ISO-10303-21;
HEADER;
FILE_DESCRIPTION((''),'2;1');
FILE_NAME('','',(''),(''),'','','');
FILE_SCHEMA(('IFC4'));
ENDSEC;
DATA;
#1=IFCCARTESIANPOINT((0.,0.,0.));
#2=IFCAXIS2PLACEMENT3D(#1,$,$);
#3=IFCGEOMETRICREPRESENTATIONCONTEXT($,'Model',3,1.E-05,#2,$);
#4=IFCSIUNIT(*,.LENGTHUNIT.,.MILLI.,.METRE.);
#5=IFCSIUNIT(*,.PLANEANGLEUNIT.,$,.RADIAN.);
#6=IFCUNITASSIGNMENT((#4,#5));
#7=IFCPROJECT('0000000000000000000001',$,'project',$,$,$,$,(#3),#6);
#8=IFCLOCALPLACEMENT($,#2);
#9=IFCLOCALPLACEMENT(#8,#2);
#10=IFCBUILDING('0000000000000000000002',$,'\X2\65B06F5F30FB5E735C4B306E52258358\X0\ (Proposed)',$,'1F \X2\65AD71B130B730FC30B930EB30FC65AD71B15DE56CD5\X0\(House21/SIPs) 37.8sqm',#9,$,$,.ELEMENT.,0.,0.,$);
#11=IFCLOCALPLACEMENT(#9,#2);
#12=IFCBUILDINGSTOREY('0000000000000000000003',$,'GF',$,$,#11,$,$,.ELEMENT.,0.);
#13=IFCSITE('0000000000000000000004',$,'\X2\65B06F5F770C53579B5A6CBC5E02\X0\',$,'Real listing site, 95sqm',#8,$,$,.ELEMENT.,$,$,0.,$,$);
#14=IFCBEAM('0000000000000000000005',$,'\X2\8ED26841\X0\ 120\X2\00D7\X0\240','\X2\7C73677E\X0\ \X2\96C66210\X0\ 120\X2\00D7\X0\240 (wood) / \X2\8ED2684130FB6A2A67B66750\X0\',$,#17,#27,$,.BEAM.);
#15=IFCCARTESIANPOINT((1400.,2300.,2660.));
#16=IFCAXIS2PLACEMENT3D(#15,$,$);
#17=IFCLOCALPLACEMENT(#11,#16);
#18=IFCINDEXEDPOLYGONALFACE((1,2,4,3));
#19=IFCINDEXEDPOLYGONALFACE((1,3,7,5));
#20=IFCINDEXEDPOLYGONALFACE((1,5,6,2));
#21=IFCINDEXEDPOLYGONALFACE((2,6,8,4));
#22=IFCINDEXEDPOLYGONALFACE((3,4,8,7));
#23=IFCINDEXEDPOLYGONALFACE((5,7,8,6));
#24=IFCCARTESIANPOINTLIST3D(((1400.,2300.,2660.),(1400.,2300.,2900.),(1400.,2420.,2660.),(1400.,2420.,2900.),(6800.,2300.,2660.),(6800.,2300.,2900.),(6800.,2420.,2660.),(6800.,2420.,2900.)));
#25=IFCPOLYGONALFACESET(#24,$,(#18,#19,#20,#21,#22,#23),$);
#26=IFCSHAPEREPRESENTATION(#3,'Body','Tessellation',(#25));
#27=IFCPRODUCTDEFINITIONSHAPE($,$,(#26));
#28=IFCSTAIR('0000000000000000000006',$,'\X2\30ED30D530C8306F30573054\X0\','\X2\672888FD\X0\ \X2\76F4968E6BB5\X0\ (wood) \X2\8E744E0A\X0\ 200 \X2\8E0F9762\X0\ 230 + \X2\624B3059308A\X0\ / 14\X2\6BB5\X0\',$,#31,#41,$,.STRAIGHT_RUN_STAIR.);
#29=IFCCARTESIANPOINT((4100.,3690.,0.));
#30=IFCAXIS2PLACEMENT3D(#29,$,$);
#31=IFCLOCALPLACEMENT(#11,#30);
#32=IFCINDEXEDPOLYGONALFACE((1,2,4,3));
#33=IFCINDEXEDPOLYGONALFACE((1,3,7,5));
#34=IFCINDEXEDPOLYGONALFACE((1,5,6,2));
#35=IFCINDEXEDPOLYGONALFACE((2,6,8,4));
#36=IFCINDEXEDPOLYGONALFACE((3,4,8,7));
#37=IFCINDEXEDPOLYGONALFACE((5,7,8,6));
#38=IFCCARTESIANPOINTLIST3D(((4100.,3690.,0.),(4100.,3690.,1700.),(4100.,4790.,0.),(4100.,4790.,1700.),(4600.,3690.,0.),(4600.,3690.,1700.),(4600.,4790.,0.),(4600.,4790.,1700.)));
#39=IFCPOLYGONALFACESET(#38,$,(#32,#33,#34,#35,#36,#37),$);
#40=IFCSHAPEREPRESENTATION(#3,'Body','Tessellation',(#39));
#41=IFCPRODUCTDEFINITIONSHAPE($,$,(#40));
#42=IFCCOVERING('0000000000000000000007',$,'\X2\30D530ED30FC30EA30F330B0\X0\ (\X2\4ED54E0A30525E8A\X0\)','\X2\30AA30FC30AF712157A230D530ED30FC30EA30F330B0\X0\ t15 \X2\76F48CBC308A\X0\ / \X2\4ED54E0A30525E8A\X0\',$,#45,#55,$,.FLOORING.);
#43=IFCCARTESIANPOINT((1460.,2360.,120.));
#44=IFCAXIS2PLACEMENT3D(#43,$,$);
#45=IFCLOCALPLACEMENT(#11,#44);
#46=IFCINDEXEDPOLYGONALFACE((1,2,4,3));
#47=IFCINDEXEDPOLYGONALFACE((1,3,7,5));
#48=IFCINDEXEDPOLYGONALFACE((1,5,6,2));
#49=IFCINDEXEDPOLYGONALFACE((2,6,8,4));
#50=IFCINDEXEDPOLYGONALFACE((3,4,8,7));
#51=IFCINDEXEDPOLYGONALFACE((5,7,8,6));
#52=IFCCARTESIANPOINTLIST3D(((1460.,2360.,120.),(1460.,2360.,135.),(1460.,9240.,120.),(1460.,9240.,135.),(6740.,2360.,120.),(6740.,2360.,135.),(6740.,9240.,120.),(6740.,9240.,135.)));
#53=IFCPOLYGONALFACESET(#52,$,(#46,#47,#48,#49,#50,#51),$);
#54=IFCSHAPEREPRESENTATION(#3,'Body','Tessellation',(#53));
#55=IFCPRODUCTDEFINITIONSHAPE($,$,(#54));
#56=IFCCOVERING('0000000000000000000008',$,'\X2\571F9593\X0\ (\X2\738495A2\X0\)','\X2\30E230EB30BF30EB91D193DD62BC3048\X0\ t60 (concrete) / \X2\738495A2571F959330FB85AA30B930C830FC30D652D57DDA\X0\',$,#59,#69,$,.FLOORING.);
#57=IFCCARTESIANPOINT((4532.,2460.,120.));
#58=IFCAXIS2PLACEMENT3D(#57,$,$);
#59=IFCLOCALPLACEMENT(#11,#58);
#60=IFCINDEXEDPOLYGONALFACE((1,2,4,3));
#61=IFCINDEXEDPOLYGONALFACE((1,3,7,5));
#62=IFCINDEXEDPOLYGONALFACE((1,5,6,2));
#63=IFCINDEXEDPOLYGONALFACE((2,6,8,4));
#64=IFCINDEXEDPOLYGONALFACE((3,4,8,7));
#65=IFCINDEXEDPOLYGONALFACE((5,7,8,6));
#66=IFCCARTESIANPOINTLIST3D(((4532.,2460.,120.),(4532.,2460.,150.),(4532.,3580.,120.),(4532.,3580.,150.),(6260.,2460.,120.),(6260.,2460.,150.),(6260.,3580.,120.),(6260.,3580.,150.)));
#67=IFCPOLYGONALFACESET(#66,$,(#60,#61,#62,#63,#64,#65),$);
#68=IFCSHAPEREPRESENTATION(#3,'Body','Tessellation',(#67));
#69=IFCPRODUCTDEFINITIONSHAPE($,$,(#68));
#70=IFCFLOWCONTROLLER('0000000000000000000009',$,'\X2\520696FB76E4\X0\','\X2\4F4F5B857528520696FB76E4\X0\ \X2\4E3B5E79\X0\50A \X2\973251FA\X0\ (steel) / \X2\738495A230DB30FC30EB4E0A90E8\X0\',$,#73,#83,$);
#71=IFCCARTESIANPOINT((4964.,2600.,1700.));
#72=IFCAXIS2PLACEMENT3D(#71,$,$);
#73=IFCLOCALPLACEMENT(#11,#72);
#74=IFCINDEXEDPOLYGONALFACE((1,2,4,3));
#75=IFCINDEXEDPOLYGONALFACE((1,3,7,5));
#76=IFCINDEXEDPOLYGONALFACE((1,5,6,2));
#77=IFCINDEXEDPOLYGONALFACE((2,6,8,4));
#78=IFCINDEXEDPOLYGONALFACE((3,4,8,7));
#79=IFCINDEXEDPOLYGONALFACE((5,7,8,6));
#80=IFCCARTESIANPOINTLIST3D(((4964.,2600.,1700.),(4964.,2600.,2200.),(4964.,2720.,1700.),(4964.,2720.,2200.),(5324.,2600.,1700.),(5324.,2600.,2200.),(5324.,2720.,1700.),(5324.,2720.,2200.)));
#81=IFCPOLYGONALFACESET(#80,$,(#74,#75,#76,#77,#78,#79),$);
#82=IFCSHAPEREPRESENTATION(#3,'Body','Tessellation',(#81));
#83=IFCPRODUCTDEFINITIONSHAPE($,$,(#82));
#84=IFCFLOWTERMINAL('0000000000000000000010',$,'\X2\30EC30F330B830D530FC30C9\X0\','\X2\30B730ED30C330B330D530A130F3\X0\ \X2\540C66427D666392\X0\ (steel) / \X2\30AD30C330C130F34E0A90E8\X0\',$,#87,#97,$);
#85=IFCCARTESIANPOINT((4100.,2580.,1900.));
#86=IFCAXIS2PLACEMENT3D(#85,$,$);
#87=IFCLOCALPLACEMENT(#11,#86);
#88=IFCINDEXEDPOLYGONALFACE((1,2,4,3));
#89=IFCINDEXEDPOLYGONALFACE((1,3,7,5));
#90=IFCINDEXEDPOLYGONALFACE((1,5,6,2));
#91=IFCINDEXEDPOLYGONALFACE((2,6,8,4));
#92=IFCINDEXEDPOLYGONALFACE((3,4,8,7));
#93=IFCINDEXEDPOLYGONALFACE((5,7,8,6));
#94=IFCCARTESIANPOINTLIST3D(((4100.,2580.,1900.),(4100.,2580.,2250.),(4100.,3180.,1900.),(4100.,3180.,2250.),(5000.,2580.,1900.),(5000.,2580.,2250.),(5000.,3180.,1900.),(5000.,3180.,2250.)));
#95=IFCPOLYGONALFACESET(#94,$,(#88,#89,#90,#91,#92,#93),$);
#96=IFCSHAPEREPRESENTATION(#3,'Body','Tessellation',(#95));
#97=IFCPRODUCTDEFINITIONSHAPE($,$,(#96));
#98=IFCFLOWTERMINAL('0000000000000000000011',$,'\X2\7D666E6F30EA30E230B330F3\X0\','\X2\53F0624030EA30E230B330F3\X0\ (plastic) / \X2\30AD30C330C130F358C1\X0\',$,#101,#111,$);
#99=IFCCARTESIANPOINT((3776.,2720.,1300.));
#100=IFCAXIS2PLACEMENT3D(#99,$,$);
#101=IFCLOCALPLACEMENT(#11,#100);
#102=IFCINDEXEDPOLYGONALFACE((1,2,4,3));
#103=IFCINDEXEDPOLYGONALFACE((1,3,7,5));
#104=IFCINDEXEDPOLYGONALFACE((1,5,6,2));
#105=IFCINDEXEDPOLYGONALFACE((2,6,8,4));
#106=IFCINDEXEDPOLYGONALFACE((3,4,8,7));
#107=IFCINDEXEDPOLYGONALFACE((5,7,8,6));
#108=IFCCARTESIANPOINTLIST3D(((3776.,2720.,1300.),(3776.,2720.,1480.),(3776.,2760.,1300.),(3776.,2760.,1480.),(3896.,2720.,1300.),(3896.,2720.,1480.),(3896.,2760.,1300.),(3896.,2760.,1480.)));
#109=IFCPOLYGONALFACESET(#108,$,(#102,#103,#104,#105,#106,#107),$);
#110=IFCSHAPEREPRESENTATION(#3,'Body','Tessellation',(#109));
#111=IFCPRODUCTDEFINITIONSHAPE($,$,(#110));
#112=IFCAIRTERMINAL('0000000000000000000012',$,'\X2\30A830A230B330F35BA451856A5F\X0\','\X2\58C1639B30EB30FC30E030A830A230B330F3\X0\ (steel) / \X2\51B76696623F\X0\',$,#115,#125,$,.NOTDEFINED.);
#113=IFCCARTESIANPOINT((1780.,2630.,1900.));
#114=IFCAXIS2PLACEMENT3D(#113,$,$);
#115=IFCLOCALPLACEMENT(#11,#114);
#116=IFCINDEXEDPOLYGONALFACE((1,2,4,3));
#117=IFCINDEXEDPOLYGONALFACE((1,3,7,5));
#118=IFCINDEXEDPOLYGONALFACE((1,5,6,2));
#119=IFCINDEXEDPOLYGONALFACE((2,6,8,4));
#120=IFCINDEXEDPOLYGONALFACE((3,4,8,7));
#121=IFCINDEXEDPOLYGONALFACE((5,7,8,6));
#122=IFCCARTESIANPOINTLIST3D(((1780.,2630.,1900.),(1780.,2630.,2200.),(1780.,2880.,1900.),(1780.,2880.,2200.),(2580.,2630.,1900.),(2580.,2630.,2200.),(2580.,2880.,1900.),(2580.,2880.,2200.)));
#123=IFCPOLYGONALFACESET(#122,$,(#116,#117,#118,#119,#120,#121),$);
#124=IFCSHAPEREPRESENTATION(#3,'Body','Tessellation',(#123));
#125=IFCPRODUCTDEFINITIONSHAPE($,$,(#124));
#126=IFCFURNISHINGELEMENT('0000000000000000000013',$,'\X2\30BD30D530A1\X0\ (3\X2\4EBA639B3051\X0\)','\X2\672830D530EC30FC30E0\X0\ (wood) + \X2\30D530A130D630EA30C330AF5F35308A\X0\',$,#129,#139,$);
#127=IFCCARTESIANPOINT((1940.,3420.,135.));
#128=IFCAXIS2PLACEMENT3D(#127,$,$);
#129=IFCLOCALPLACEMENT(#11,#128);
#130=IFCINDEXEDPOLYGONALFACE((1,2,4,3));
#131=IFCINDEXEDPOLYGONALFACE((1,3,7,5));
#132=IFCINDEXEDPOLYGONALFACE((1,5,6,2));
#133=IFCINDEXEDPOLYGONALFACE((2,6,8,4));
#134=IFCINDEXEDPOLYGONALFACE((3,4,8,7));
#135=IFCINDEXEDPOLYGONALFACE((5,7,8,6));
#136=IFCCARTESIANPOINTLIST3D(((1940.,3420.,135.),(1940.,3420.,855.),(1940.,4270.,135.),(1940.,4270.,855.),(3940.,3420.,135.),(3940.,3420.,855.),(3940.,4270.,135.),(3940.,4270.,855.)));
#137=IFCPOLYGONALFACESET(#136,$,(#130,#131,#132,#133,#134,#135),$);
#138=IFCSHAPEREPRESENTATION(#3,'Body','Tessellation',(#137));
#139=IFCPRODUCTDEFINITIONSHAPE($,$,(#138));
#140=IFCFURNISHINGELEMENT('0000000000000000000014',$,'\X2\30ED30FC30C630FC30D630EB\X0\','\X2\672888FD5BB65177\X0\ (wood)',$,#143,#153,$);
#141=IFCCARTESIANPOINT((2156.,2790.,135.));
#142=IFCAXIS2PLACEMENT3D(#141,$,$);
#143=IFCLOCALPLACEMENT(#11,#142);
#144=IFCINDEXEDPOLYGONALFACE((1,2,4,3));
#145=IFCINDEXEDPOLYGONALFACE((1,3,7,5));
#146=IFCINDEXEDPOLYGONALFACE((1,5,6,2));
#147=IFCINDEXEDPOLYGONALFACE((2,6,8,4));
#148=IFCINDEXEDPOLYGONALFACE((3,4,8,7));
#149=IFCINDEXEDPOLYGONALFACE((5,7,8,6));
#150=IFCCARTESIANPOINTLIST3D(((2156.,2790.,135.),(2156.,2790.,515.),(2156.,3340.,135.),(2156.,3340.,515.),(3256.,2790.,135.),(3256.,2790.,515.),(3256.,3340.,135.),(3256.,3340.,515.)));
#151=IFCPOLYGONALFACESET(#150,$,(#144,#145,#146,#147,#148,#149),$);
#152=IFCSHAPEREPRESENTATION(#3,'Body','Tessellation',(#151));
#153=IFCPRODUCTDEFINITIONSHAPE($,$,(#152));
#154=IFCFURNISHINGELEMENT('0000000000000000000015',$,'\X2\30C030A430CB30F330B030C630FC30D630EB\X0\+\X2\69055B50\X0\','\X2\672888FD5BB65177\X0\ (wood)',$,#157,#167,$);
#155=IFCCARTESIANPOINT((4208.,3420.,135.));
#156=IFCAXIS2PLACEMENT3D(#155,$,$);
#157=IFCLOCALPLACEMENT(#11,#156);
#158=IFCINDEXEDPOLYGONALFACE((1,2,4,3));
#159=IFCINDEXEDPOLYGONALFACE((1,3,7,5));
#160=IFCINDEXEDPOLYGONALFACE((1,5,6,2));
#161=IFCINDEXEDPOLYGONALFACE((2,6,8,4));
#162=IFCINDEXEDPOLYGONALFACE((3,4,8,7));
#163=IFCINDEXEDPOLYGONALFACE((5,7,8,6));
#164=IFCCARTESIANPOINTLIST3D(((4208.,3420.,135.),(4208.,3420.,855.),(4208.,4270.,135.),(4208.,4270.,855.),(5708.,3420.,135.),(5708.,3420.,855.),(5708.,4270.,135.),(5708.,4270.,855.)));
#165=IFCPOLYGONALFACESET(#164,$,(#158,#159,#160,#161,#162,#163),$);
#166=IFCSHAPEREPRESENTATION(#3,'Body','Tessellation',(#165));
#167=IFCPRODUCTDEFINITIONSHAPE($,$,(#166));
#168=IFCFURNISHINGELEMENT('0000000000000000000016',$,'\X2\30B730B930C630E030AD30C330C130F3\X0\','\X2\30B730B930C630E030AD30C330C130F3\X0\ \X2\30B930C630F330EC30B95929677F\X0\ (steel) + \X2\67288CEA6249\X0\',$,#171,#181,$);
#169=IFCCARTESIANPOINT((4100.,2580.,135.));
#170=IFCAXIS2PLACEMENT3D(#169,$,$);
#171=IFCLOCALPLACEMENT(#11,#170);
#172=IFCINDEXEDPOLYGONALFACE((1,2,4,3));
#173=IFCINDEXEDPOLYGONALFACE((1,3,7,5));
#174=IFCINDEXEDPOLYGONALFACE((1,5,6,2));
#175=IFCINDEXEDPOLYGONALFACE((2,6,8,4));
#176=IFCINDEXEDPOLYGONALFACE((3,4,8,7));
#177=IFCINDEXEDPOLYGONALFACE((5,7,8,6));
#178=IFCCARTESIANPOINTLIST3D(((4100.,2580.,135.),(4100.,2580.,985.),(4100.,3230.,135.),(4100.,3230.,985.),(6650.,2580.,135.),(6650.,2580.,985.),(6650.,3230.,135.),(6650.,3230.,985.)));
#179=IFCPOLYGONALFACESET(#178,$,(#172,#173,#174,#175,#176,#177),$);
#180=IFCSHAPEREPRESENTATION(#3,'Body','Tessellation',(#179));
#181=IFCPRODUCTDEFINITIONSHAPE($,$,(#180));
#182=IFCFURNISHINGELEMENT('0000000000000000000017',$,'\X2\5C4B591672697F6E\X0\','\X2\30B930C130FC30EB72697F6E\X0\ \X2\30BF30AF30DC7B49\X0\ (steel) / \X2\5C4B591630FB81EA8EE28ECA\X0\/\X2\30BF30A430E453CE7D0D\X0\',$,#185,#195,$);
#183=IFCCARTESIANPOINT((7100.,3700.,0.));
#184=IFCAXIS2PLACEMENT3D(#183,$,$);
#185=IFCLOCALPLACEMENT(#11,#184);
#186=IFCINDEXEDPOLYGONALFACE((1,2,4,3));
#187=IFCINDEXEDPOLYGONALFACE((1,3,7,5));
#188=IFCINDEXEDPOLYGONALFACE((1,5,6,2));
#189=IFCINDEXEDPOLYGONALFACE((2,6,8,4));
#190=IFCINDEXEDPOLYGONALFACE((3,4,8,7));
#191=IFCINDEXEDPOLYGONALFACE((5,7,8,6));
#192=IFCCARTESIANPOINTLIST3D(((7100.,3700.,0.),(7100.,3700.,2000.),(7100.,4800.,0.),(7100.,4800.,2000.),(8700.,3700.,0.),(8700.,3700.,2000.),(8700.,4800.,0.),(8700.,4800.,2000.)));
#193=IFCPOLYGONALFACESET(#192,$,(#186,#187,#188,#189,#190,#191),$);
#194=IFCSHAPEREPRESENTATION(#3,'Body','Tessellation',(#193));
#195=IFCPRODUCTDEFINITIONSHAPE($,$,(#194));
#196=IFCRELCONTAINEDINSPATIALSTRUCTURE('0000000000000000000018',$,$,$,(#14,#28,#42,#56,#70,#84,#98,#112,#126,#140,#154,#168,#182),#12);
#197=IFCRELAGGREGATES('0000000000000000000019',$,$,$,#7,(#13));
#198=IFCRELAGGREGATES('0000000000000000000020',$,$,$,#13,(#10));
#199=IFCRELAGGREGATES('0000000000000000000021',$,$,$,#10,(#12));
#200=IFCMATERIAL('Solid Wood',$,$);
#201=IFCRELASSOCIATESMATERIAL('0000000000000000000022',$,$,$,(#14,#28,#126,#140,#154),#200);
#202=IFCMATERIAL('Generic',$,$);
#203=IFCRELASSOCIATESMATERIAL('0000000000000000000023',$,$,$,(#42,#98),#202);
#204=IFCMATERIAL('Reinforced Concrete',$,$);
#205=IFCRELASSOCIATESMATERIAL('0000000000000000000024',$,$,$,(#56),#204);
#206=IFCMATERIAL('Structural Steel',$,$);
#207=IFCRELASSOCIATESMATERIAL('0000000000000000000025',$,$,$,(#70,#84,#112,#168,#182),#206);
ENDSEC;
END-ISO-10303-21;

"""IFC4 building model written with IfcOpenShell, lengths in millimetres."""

from ifc_helpers import new_model, si_unit, frame, frame_2d, origin, place, context, project, spatial, rectangle, extrude, material, element, save


model = new_model("IFC4")

# Units and contexts
model_context = context("Model", 3, precision=1e-05, world=origin())
ifc_project = project(units=[si_unit("LENGTHUNIT", "METRE", prefix="MILLI"), si_unit("PLANEANGLEUNIT", "RADIAN")], contexts=[model_context])

# Site, building, storey
site_placement = place(None, origin())
site = spatial("IfcSite", under=ifc_project, at=site_placement, Name="新潟県南魚沼市", ObjectType="Real listing site, 95sqm", CompositionType="ELEMENT", RefElevation=0.0)
building_placement = place(site_placement, origin())
building = spatial("IfcBuilding", under=site, at=building_placement, Name="新潟・平屋の別荘 (Proposed)", ObjectType="1F 断熱シースルー断熱工法(House21/SIPs) 37.8sqm", CompositionType="ELEMENT", ElevationOfRefHeight=0.0, ElevationOfTerrain=0.0)
storey_placement = place(building_placement, origin())
storey = spatial("IfcBuildingStorey", under=building, at=storey_placement, Name="GF", CompositionType="ELEMENT", Elevation=0.0)

# Beam
ifc_material_1 = material(Name="Solid Wood")
beam_1_placement = place(storey_placement, frame((1400.0, 2300.0, 2660.0)))
element("IfcBeam", 1, at=beam_1_placement, inside=storey, material=ifc_material_1, Name="軒桁 120×240", Description="米松 集成 120×240 (wood) / 軒桁・横架材", PredefinedType="BEAM", context=model_context, shape_type="SweptSolid", body=[
    extrude(rectangle(XDim=5400.0, YDim=120.0, at=frame_2d((2700.0, 60.0))), frame((1400.0, 2300.0, 2660.0)), (0.0, 0.0, 1.0), 240.0),
])

# Stair
stair_placement = place(storey_placement, frame((4100.0, 3690.0, 0.0)))
element("IfcStair", 2, at=stair_placement, inside=storey, material=ifc_material_1, Name="ロフトはしご", Description="木製 直階段 (wood) 蹴上 200 踏面 230 + 手すり / 14段", PredefinedType="STRAIGHT_RUN_STAIR", context=model_context, shape_type="SweptSolid", body=[
    extrude(rectangle(XDim=500.0, YDim=1100.0, at=frame_2d((250.0, 550.0))), frame((4100.0, 3690.0, 0.0)), (0.0, 0.0, 1.0), 1700.0),
])

# Coverings
ifc_material_2 = material(Name="Generic")
covering_1_placement = place(storey_placement, frame((1460.0, 2360.0, 120.0)))
element("IfcCovering", 3, at=covering_1_placement, inside=storey, material=ifc_material_2, Name="フローリング (仕上げ床)", Description="オーク無垢フローリング t15 直貼り / 仕上げ床", PredefinedType="FLOORING", context=model_context, shape_type="SweptSolid", body=[
    extrude(rectangle(XDim=5280.0, YDim=6880.0, at=frame_2d((2640.0, 3440.0))), frame((1460.0, 2360.0, 120.0)), (0.0, 0.0, 1.0), 15.0),
])
ifc_material_3 = material(Name="Reinforced Concrete")
covering_2_placement = place(storey_placement, frame((4532.0, 2460.0, 120.0)))
element("IfcCovering", 4, at=covering_2_placement, inside=storey, material=ifc_material_3, Name="土間 (玄関)", Description="モルタル金鏝押え t60 (concrete) / 玄関土間・薪ストーブ動線", PredefinedType="FLOORING", context=model_context, shape_type="SweptSolid", body=[
    extrude(rectangle(XDim=1728.0, YDim=1120.0, at=frame_2d((864.0, 560.0))), frame((4532.0, 2460.0, 120.0)), (0.0, 0.0, 1.0), 30.0),
])

# Flow controller
ifc_material_4 = material(Name="Structural Steel")
flow_controller_placement = place(storey_placement, frame((4964.0, 2600.0, 1700.0)))
element("IfcFlowController", 5, at=flow_controller_placement, inside=storey, material=ifc_material_4, Name="分電盤", Description="住宅用分電盤 主幹50A 露出 (steel) / 玄関ホール上部", context=model_context, shape_type="SweptSolid", body=[
    extrude(rectangle(XDim=360.0, YDim=120.0, at=frame_2d((180.0, 60.0))), frame((4964.0, 2600.0, 1700.0)), (0.0, 0.0, 1.0), 500.0),
])

# Flow terminals
flow_terminal_1_placement = place(storey_placement, frame((4100.0, 2580.0, 1900.0)))
element("IfcFlowTerminal", 6, at=flow_terminal_1_placement, inside=storey, material=ifc_material_4, Name="レンジフード", Description="シロッコファン 同時給排 (steel) / キッチン上部", context=model_context, shape_type="SweptSolid", body=[
    extrude(rectangle(XDim=900.0, YDim=600.0, at=frame_2d((450.0, 300.0))), frame((4100.0, 2580.0, 1900.0)), (0.0, 0.0, 1.0), 350.0),
])
flow_terminal_2_placement = place(storey_placement, frame((3776.0, 2720.0, 1300.0)))
element("IfcFlowTerminal", 7, at=flow_terminal_2_placement, inside=storey, material=ifc_material_2, Name="給湯リモコン", Description="台所リモコン (plastic) / キッチン壁", context=model_context, shape_type="SweptSolid", body=[
    extrude(rectangle(XDim=120.0, YDim=40.0, at=frame_2d((60.0, 20.0))), frame((3776.0, 2720.0, 1300.0)), (0.0, 0.0, 1.0), 180.0),
])

# Air terminal
air_terminal_placement = place(storey_placement, frame((1780.0, 2630.0, 1900.0)))
element("IfcAirTerminal", 8, at=air_terminal_placement, inside=storey, material=ifc_material_4, Name="エアコン室内機", Description="壁掛ルームエアコン (steel) / 冷暖房", PredefinedType="NOTDEFINED", context=model_context, shape_type="SweptSolid", body=[
    extrude(rectangle(XDim=800.0, YDim=250.0, at=frame_2d((400.0, 125.0))), frame((1780.0, 2630.0, 1900.0)), (0.0, 0.0, 1.0), 300.0),
])

# Furnishing elements
furnishing_1_placement = place(storey_placement, frame((1940.0, 3420.0, 135.0)))
element("IfcFurnishingElement", 9, at=furnishing_1_placement, inside=storey, material=ifc_material_1, Name="ソファ (3人掛け)", Description="木フレーム (wood) + ファブリック張り", context=model_context, shape_type="SweptSolid", body=[
    extrude(rectangle(XDim=2000.0, YDim=850.0, at=frame_2d((1000.0, 425.0))), frame((1940.0, 3420.0, 135.0)), (0.0, 0.0, 1.0), 720.0),
])
furnishing_2_placement = place(storey_placement, frame((2156.0, 2790.0, 135.0)))
element("IfcFurnishingElement", 10, at=furnishing_2_placement, inside=storey, material=ifc_material_1, Name="ローテーブル", Description="木製家具 (wood)", context=model_context, shape_type="SweptSolid", body=[
    extrude(rectangle(XDim=1100.0, YDim=550.0, at=frame_2d((550.0, 275.0))), frame((2156.0, 2790.0, 135.0)), (0.0, 0.0, 1.0), 380.0),
])
furnishing_3_placement = place(storey_placement, frame((4208.0, 3420.0, 135.0)))
element("IfcFurnishingElement", 11, at=furnishing_3_placement, inside=storey, material=ifc_material_1, Name="ダイニングテーブル+椅子", Description="木製家具 (wood)", context=model_context, shape_type="SweptSolid", body=[
    extrude(rectangle(XDim=1500.0, YDim=850.0, at=frame_2d((750.0, 425.0))), frame((4208.0, 3420.0, 135.0)), (0.0, 0.0, 1.0), 720.0),
])
furnishing_4_placement = place(storey_placement, frame((4100.0, 2580.0, 135.0)))
element("IfcFurnishingElement", 12, at=furnishing_4_placement, inside=storey, material=ifc_material_4, Name="システムキッチン", Description="システムキッチン ステンレス天板 (steel) + 木質扉", context=model_context, shape_type="SweptSolid", body=[
    extrude(rectangle(XDim=2550.0, YDim=650.0, at=frame_2d((1275.0, 325.0))), frame((4100.0, 2580.0, 135.0)), (0.0, 0.0, 1.0), 850.0),
])
furnishing_5_placement = place(storey_placement, frame((7100.0, 3700.0, 0.0)))
element("IfcFurnishingElement", 13, at=furnishing_5_placement, inside=storey, material=ifc_material_4, Name="屋外物置", Description="スチール物置 タクボ等 (steel) / 屋外・自転車/タイヤ収納", context=model_context, shape_type="SweptSolid", body=[
    extrude(rectangle(XDim=1600.0, YDim=1100.0, at=frame_2d((800.0, 550.0))), frame((7100.0, 3700.0, 0.0)), (0.0, 0.0, 1.0), 2000.0),
])

save(model, "model.ifc")
